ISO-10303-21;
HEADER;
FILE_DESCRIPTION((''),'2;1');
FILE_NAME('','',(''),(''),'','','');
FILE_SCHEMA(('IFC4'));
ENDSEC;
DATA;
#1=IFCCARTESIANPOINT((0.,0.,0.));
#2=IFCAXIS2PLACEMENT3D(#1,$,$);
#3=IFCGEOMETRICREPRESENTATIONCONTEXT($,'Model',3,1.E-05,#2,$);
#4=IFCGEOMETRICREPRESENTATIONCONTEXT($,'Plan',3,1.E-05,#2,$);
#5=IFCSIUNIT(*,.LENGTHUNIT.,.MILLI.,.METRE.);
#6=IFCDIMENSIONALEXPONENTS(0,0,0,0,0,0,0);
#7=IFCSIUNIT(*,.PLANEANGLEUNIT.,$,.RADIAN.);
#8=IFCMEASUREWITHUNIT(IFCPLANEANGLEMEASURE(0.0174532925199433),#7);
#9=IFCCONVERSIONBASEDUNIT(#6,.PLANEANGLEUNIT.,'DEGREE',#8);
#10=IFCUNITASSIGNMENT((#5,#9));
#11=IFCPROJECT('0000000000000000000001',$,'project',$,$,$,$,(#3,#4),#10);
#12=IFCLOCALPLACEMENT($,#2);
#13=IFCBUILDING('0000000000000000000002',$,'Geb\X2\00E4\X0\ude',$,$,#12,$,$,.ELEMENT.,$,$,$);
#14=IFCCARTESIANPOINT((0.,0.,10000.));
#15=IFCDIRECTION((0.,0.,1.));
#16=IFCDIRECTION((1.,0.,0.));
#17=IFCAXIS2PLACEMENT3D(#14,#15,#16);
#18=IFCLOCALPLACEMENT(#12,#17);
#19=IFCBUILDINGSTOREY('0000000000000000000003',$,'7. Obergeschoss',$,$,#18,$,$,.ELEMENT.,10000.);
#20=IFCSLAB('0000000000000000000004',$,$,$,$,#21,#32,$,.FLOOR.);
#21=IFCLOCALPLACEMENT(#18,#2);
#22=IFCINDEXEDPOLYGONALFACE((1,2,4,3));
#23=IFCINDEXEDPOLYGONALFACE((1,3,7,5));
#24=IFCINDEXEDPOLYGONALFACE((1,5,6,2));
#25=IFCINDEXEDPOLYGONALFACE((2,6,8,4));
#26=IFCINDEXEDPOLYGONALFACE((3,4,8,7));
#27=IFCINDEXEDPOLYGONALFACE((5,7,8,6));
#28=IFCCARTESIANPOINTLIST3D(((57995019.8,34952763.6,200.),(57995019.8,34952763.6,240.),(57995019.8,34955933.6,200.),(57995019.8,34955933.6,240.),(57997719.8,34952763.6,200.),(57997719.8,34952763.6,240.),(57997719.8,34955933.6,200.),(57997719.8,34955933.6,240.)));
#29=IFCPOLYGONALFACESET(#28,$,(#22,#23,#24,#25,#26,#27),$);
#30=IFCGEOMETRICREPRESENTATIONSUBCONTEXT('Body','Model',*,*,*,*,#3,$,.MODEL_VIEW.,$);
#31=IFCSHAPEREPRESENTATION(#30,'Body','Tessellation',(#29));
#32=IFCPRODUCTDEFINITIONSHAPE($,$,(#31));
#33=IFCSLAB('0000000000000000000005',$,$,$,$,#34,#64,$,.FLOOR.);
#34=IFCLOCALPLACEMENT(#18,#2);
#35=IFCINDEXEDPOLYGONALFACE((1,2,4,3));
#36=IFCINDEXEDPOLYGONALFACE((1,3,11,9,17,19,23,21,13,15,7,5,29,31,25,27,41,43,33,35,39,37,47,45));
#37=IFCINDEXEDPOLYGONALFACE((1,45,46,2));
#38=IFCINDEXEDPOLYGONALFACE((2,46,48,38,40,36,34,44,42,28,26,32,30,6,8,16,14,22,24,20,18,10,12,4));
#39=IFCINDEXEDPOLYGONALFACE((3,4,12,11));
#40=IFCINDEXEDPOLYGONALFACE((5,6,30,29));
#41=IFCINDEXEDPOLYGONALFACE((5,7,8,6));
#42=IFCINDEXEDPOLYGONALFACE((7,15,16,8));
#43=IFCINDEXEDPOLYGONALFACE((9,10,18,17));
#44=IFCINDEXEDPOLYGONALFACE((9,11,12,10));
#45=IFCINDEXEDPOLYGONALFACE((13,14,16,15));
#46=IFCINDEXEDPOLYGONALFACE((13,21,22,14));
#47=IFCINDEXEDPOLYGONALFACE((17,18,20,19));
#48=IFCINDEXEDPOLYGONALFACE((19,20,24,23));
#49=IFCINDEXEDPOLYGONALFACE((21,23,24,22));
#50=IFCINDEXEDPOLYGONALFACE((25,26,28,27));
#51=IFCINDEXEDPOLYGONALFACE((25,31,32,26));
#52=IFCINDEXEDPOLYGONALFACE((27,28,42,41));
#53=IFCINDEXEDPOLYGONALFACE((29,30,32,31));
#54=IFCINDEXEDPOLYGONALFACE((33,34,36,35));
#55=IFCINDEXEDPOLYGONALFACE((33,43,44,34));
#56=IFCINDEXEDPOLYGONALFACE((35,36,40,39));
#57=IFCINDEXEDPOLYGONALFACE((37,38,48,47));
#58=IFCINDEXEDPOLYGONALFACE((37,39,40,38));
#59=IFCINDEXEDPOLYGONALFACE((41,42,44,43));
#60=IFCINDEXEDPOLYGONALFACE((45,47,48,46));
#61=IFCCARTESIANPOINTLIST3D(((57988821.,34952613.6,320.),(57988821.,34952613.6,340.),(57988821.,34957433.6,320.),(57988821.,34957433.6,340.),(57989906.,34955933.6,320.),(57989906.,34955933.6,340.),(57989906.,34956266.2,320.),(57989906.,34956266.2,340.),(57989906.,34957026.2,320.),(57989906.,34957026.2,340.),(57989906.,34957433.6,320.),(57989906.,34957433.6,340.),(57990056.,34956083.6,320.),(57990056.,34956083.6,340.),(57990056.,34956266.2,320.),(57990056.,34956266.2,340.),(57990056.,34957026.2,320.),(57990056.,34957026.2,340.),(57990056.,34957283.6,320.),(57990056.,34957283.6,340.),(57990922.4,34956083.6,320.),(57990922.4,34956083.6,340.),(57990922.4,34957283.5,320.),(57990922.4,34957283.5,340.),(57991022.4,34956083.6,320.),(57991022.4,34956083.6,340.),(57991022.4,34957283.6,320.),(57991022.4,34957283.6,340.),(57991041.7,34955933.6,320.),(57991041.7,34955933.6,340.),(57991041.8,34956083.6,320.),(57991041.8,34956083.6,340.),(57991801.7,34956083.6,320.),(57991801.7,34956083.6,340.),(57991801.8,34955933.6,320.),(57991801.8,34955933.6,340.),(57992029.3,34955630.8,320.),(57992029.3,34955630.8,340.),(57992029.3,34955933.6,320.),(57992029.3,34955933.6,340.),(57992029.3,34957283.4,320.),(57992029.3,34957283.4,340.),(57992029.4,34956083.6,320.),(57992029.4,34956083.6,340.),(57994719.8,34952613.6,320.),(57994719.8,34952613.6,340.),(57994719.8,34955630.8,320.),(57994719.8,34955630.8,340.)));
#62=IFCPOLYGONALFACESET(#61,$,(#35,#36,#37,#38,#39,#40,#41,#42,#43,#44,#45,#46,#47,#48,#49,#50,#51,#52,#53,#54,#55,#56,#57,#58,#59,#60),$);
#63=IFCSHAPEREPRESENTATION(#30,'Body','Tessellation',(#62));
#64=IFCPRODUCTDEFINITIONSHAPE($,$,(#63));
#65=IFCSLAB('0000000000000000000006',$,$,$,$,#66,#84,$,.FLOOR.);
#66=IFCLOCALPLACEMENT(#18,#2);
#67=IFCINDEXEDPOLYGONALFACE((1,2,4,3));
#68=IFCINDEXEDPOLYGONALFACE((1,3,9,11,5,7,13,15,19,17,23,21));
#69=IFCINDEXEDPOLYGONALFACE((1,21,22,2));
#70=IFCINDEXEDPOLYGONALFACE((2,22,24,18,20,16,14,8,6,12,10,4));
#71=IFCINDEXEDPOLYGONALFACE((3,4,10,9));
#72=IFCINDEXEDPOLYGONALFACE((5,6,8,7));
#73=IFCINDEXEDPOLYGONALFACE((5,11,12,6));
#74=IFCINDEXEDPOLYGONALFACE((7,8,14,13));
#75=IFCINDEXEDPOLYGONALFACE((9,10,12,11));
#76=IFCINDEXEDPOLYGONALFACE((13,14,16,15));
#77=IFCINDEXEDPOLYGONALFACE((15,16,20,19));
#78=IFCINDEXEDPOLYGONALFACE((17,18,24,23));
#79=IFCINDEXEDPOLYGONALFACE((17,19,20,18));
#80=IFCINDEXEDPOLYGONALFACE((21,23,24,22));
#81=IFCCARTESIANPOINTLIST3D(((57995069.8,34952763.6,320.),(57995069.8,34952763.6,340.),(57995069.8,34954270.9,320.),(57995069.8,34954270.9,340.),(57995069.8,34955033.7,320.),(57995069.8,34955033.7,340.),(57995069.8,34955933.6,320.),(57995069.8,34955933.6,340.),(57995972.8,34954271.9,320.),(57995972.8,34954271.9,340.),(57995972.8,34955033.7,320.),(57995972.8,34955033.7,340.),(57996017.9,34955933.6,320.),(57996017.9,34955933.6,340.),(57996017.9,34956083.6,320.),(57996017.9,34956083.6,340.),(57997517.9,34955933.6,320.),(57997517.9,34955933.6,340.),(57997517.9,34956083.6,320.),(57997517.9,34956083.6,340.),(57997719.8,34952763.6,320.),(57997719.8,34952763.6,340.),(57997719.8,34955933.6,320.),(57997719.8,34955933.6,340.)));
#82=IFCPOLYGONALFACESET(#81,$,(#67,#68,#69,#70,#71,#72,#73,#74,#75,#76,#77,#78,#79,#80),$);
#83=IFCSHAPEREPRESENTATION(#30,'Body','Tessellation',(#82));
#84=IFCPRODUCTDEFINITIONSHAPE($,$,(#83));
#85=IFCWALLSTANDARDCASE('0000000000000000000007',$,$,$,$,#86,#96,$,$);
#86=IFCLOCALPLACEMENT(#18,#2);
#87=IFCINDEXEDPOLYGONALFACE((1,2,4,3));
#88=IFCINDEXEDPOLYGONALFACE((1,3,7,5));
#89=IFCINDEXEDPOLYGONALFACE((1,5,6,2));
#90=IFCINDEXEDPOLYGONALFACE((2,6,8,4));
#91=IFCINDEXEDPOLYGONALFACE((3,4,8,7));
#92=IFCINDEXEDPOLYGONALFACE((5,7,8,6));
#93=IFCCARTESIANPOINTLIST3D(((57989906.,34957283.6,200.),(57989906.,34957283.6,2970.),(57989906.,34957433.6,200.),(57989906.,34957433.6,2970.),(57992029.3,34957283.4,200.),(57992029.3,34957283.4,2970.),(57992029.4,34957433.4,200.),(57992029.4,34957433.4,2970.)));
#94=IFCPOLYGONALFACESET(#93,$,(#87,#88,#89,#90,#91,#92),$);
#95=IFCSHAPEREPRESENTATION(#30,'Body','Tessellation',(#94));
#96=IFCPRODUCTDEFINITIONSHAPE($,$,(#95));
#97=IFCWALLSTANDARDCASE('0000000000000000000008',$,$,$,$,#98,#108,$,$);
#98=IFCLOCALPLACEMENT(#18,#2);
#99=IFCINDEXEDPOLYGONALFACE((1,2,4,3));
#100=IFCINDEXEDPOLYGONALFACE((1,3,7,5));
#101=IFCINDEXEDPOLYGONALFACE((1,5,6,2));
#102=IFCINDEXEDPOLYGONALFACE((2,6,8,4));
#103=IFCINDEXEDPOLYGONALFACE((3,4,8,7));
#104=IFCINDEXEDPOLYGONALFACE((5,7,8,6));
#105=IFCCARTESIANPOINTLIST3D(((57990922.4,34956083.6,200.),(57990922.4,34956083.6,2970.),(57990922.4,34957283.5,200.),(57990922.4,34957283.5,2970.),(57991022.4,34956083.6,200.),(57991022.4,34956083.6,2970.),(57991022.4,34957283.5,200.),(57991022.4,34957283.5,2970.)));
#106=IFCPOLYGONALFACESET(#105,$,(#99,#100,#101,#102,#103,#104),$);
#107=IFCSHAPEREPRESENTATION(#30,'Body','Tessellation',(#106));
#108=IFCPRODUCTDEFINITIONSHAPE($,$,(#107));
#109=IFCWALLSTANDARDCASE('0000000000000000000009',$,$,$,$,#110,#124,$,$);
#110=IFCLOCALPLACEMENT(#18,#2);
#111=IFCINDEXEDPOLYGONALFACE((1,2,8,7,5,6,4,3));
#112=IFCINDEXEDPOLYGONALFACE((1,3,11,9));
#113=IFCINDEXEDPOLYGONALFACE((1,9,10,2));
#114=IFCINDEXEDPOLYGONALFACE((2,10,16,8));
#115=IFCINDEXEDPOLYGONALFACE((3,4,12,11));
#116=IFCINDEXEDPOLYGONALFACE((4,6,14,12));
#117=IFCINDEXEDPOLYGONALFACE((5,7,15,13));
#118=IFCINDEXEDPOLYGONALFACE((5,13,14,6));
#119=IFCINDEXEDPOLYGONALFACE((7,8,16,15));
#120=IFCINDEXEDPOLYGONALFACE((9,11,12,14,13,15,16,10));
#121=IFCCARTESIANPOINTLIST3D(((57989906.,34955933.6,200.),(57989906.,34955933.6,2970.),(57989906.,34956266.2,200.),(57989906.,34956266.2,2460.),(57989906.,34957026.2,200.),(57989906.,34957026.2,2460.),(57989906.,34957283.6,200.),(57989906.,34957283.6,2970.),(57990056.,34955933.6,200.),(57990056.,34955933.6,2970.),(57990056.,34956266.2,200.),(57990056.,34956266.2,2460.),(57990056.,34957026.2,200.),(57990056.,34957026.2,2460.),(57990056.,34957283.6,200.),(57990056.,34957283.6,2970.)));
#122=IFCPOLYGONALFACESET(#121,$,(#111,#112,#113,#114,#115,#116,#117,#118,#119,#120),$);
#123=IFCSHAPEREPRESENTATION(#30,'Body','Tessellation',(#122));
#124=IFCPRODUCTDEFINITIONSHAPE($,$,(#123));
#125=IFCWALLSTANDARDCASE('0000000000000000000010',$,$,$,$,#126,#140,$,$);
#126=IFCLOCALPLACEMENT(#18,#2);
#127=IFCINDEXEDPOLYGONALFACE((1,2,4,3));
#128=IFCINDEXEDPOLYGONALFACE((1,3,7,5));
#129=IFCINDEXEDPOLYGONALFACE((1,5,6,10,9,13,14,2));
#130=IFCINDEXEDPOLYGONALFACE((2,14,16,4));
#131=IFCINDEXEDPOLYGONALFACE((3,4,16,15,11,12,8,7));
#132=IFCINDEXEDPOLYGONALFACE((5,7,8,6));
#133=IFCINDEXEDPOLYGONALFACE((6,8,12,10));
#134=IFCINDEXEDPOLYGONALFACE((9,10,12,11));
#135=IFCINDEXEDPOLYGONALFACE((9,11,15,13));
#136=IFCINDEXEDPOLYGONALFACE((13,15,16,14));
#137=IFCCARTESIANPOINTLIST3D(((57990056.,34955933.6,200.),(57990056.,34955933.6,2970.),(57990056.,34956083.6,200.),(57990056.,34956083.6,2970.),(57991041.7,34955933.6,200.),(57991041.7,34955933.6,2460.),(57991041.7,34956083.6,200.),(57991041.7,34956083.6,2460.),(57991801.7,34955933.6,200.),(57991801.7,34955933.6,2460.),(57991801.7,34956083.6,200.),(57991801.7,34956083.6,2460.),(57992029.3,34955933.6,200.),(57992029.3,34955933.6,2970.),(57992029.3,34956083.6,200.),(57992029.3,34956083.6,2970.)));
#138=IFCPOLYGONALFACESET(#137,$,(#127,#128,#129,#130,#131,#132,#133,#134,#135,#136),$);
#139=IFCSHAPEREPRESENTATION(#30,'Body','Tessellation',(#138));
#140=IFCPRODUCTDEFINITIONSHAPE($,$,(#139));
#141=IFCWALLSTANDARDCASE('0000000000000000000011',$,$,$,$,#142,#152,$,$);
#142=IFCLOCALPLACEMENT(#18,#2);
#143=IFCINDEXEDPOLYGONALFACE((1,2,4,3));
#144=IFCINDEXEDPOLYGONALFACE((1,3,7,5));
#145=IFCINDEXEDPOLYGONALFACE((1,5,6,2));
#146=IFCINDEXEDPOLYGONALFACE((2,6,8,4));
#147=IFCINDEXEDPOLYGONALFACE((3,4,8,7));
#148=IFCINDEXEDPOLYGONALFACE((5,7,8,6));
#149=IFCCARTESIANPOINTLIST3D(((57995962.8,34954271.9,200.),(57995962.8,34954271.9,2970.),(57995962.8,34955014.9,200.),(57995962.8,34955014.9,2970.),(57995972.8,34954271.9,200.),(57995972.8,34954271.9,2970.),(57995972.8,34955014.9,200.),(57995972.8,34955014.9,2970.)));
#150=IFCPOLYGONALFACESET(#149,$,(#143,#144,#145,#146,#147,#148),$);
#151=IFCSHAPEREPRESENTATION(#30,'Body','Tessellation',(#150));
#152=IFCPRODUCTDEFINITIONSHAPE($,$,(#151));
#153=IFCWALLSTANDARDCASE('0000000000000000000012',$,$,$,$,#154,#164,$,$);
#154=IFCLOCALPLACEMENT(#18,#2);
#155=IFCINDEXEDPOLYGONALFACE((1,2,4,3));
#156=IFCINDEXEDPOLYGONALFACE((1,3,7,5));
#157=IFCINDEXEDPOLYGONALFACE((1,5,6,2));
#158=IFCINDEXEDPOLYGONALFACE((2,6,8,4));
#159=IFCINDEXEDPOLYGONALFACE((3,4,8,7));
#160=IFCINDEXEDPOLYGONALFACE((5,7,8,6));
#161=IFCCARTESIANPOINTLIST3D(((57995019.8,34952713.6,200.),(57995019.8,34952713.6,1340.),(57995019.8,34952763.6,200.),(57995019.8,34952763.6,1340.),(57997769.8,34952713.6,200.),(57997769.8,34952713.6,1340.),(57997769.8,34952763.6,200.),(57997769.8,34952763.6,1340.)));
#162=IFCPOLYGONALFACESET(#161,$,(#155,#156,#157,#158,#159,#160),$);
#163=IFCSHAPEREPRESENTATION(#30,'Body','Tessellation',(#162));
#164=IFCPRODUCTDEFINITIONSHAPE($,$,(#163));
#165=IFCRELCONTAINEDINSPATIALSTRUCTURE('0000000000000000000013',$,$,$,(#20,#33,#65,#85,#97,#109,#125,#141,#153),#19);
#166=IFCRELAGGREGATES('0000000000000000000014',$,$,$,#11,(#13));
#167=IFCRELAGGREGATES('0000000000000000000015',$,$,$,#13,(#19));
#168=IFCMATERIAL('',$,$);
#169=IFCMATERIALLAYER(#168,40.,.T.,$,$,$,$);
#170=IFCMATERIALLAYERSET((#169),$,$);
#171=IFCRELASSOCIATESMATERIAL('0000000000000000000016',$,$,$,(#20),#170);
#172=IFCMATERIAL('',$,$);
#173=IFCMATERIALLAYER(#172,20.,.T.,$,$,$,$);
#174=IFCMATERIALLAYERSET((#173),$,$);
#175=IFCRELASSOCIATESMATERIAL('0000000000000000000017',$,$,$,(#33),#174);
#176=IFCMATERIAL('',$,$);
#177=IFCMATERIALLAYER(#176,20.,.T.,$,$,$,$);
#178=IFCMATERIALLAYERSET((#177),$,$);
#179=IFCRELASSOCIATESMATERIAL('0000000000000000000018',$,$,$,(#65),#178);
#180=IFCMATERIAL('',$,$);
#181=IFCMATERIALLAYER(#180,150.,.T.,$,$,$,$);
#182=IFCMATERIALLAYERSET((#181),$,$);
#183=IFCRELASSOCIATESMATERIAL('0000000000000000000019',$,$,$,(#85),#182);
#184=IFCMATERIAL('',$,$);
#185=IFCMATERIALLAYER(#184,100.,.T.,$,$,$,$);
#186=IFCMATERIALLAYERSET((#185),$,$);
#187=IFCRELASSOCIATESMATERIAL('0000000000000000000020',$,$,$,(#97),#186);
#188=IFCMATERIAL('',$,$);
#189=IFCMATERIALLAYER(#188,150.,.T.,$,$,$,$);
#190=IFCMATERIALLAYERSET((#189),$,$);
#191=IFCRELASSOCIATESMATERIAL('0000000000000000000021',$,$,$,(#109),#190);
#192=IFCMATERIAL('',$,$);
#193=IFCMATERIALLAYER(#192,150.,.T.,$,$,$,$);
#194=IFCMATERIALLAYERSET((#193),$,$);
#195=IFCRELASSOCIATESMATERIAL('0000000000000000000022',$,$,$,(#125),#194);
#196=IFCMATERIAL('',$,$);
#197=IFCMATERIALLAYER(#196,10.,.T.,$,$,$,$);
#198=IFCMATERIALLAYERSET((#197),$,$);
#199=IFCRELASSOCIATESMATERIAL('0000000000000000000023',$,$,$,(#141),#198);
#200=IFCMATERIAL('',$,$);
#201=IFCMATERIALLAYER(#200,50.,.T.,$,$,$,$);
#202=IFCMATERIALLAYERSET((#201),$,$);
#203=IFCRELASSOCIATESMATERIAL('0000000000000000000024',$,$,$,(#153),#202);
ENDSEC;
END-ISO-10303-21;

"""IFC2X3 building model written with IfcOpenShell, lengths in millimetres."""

from ifc_helpers import new_model, entity, si_unit, converted_unit, frame, frame_2d, origin, origin_with_axes, place, context, subcontext, project, spatial, polyline, rectangle, outline, extrude, material, layer, layer_set, layer_usage, element, save


model = new_model("IFC2X3")

# Units and contexts
model_context = context("Model", 3, precision=1e-05, world=origin())
plan_context = context("Plan", 3, precision=1e-05, world=origin())
body_context = subcontext(model_context, "Body", "Model", "MODEL_VIEW")
ifc_project = project(units=[si_unit("LENGTHUNIT", "METRE", prefix="MILLI"), converted_unit("PLANEANGLEUNIT", "DEGREE", entity("IfcPlaneAngleMeasure", 0.0174532925199433), si_unit("PLANEANGLEUNIT", "RADIAN"), dimensions=[0, 0, 0, 0, 0, 0, 0])], contexts=[model_context, plan_context])

# Building, storey
building_placement = place(None, origin())
building = spatial("IfcBuilding", under=ifc_project, at=building_placement, Name="Gebäude", CompositionType="ELEMENT")
storey_placement = place(building_placement, frame((0.0, 0.0, 10000.0), z_axis=(0.0, 0.0, 1.0), x_axis=(1.0, 0.0, 0.0)))
storey = spatial("IfcBuildingStorey", under=building, at=storey_placement, Name="7. Obergeschoss", CompositionType="ELEMENT", Elevation=10000.0)

# Slabs
ifc_material_1 = material(Name="")
ifc_layer_1 = layer(ifc_material_1, 40.0, ventilated=True)
ifc_layer_set_1 = layer_set([ifc_layer_1])
ifc_layer_usage_1 = layer_usage(ifc_layer_set_1, "AXIS3", "POSITIVE", 0.0)
slab_1_placement = place(storey_placement, frame((57995019.8, 34955933.6, 200.0), z_axis=(0.0, 0.0, 1.0), x_axis=(1.0, 0.0, 0.0)))
element("IfcSlab", 1, at=slab_1_placement, inside=storey, material=ifc_layer_usage_1, PredefinedType="FLOOR", context=body_context, shape_type="SweptSolid", body=[
    extrude(rectangle(XDim=3169.9, YDim=2700.0, at=frame_2d((1350.0, -1585.0), x_axis=(0.0, -1.0))), origin_with_axes(), (0.0, 0.0, 1.0), 40.0),
])
ifc_material_2 = material(Name="")
ifc_layer_2 = layer(ifc_material_2, 20.0, ventilated=True)
ifc_layer_set_2 = layer_set([ifc_layer_2])
ifc_layer_usage_2 = layer_usage(ifc_layer_set_2, "AXIS3", "POSITIVE", 0.0)
slab_2_placement = place(storey_placement, frame((57988821.0, 34952613.6, 320.0), z_axis=(0.0, 0.0, 1.0), x_axis=(1.0, 0.0, 0.0)))
element("IfcSlab", 2, at=slab_2_placement, inside=storey, material=ifc_layer_usage_2, PredefinedType="FLOOR", context=body_context, shape_type="SweptSolid", body=[
    extrude(outline(polyline([(0.0, 4819.9), (0.0, 0.0), (5898.8, 0.0), (5898.8, 3017.2), (3208.3, 3017.2), (3208.3, 3319.9), (2980.7, 3319.9), (2980.6, 3469.9), (3208.3, 3469.9), (3208.3, 4669.8), (2201.4, 4669.9), (2201.4, 3469.9), (2220.7, 3469.9), (2220.6, 3319.9), (1085.0, 3319.9), (1085.0, 3652.5), (1235.0, 3652.5), (1235.0, 3469.9), (2101.4, 3469.9), (2101.4, 4669.9), (1235.0, 4669.9), (1235.0, 4412.5), (1085.0, 4412.5), (1085.0, 4819.9), (0.0, 4819.9)])), origin_with_axes(), (0.0, 0.0, 1.0), 20.0),
])
ifc_material_3 = material(Name="")
ifc_layer_3 = layer(ifc_material_3, 20.0, ventilated=True)
ifc_layer_set_3 = layer_set([ifc_layer_3])
ifc_layer_usage_3 = layer_usage(ifc_layer_set_3, "AXIS3", "POSITIVE", 0.0)
slab_3_placement = place(storey_placement, frame((57995069.8, 34952763.6, 320.0), z_axis=(0.0, 0.0, 1.0), x_axis=(1.0, 0.0, 0.0)))
element("IfcSlab", 3, at=slab_3_placement, inside=storey, material=ifc_layer_usage_3, PredefinedType="FLOOR", context=body_context, shape_type="SweptSolid", body=[
    extrude(outline(polyline([(2650.0, 0.0), (2650.0, 3169.9), (2448.1, 3169.9), (2448.1, 3319.9), (948.1, 3319.9), (948.1, 3169.9), (0.0, 3169.9), (0.0, 2270.0), (903.0, 2270.0), (903.0, 1508.3), (0.0, 1507.2), (0.0, 0.0), (2650.0, 0.0)])), origin_with_axes(), (0.0, 0.0, 1.0), 20.0),
])

# Walls
ifc_material_4 = material(Name="")
ifc_layer_4 = layer(ifc_material_4, 150.0, ventilated=True)
ifc_layer_set_4 = layer_set([ifc_layer_4])
ifc_layer_usage_4 = layer_usage(ifc_layer_set_4, "AXIS2", "POSITIVE", 0.0)
wall_1_placement = place(storey_placement, frame((57989906.0, 34957283.6, 200.0), z_axis=(0.0, 0.0, 1.0), x_axis=(1.0, -0.000084, 0.0)))
element("IfcWallStandardCase", 4, at=wall_1_placement, inside=storey, material=ifc_layer_usage_4, context=body_context, shape_type="SweptSolid", body=[
    extrude(outline(polyline([(0.0, 0.0), (2123.3, 0.0), (2123.3, 150.0), (0.0, 150.0), (0.0, 0.0)])), origin_with_axes(), (0.0, 0.0, 1.0), 2770.0),
])
ifc_material_5 = material(Name="")
ifc_layer_5 = layer(ifc_material_5, 100.0, ventilated=True)
ifc_layer_set_5 = layer_set([ifc_layer_5])
ifc_layer_usage_5 = layer_usage(ifc_layer_set_5, "AXIS2", "POSITIVE", 0.0)
wall_2_placement = place(storey_placement, frame((57991022.4, 34956083.6, 200.0), z_axis=(0.0, 0.0, 1.0), x_axis=(0.0, 1.0, 0.0)))
element("IfcWallStandardCase", 5, at=wall_2_placement, inside=storey, material=ifc_layer_usage_5, context=body_context, shape_type="SweptSolid", body=[
    extrude(outline(polyline([(0.0, 0.0), (1199.9, 0.0), (1199.9, 100.0), (0.0, 100.0), (0.0, 0.0)])), origin_with_axes(), (0.0, 0.0, 1.0), 2770.0),
])

# Walls, openings
ifc_material_6 = material(Name="")
ifc_layer_6 = layer(ifc_material_6, 150.0, ventilated=True)
ifc_layer_set_6 = layer_set([ifc_layer_6])
ifc_layer_usage_6 = layer_usage(ifc_layer_set_6, "AXIS2", "POSITIVE", 0.0)
wall_3_placement = place(storey_placement, frame((57990056.0, 34955933.6, 200.0), z_axis=(0.0, 0.0, 1.0), x_axis=(0.0, 1.0, 0.0)))
wall_3 = element("IfcWallStandardCase", 6, at=wall_3_placement, inside=storey, material=ifc_layer_usage_6, context=body_context, shape_type="SweptSolid", body=[
    extrude(rectangle(XDim=1350.0, YDim=150.0, at=frame_2d((675.0, 75.0), x_axis=(1.0, 0.0))), origin_with_axes(), (0.0, 0.0, 1.0), 2770.0),
])
opening_1_placement = place(wall_3_placement, frame((332.6, 0.0, 0.0), z_axis=(0.0, 1.0, 0.0), x_axis=(0.0, 0.0, 1.0)))
element("IfcOpeningElement", 7, at=opening_1_placement, cuts=wall_3, ObjectType="Opening", context=body_context, shape_type="SweptSolid", body=[
    extrude(rectangle(XDim=2260.0, YDim=760.0, at=frame_2d((1130.0, 380.0), x_axis=(1.0, 0.0))), origin_with_axes(), (0.0, 0.0, 1.0), 150.0),
])
ifc_material_7 = material(Name="")
ifc_layer_7 = layer(ifc_material_7, 150.0, ventilated=True)
ifc_layer_set_7 = layer_set([ifc_layer_7])
ifc_layer_usage_7 = layer_usage(ifc_layer_set_7, "AXIS2", "POSITIVE", 0.0)
wall_4_placement = place(storey_placement, frame((57992029.3, 34956083.6, 200.0), z_axis=(0.0, 0.0, 1.0), x_axis=(-1.0, 0.0, 0.0)))
wall_4 = element("IfcWallStandardCase", 8, at=wall_4_placement, inside=storey, material=ifc_layer_usage_7, context=body_context, shape_type="SweptSolid", body=[
    extrude(rectangle(XDim=1973.3, YDim=150.0, at=frame_2d((986.6, 75.0), x_axis=(1.0, 0.0))), origin_with_axes(), (0.0, 0.0, 1.0), 2770.0),
])
opening_2_placement = place(wall_4_placement, frame((227.7, 0.0, 0.0), z_axis=(0.0, 1.0, 0.0), x_axis=(0.0, 0.0, 1.0)))
element("IfcOpeningElement", 9, at=opening_2_placement, cuts=wall_4, ObjectType="Opening", context=body_context, shape_type="SweptSolid", body=[
    extrude(rectangle(XDim=2260.0, YDim=760.0, at=frame_2d((1130.0, 380.0), x_axis=(1.0, 0.0))), origin_with_axes(), (0.0, 0.0, 1.0), 150.0),
])

# Walls
ifc_material_8 = material(Name="")
ifc_layer_8 = layer(ifc_material_8, 10.0, ventilated=True)
ifc_layer_set_8 = layer_set([ifc_layer_8])
ifc_layer_usage_8 = layer_usage(ifc_layer_set_8, "AXIS2", "POSITIVE", 0.0)
wall_5_placement = place(storey_placement, frame((57995972.8, 34954271.9, 200.0), z_axis=(0.0, 0.0, 1.0), x_axis=(0.0, 1.0, 0.0)))
element("IfcWallStandardCase", 10, at=wall_5_placement, inside=storey, material=ifc_layer_usage_8, context=body_context, shape_type="SweptSolid", body=[
    extrude(rectangle(XDim=743.0, YDim=10.0, at=frame_2d((371.5, 5.0), x_axis=(1.0, 0.0))), origin_with_axes(), (0.0, 0.0, 1.0), 2770.0),
])
ifc_material_9 = material(Name="")
ifc_layer_9 = layer(ifc_material_9, 50.0, ventilated=True)
ifc_layer_set_9 = layer_set([ifc_layer_9])
ifc_layer_usage_9 = layer_usage(ifc_layer_set_9, "AXIS2", "POSITIVE", 0.0)
wall_6_placement = place(storey_placement, frame((57997769.8, 34952763.6, 200.0), z_axis=(0.0, 0.0, 1.0), x_axis=(-1.0, 0.0, 0.0)))
element("IfcWallStandardCase", 11, at=wall_6_placement, inside=storey, material=ifc_layer_usage_9, context=body_context, shape_type="SweptSolid", body=[
    extrude(rectangle(XDim=2750.0, YDim=50.0, at=frame_2d((1375.0, 25.0), x_axis=(1.0, 0.0))), origin_with_axes(), (0.0, 0.0, 1.0), 1140.0),
])

save(model, "model.ifc")
